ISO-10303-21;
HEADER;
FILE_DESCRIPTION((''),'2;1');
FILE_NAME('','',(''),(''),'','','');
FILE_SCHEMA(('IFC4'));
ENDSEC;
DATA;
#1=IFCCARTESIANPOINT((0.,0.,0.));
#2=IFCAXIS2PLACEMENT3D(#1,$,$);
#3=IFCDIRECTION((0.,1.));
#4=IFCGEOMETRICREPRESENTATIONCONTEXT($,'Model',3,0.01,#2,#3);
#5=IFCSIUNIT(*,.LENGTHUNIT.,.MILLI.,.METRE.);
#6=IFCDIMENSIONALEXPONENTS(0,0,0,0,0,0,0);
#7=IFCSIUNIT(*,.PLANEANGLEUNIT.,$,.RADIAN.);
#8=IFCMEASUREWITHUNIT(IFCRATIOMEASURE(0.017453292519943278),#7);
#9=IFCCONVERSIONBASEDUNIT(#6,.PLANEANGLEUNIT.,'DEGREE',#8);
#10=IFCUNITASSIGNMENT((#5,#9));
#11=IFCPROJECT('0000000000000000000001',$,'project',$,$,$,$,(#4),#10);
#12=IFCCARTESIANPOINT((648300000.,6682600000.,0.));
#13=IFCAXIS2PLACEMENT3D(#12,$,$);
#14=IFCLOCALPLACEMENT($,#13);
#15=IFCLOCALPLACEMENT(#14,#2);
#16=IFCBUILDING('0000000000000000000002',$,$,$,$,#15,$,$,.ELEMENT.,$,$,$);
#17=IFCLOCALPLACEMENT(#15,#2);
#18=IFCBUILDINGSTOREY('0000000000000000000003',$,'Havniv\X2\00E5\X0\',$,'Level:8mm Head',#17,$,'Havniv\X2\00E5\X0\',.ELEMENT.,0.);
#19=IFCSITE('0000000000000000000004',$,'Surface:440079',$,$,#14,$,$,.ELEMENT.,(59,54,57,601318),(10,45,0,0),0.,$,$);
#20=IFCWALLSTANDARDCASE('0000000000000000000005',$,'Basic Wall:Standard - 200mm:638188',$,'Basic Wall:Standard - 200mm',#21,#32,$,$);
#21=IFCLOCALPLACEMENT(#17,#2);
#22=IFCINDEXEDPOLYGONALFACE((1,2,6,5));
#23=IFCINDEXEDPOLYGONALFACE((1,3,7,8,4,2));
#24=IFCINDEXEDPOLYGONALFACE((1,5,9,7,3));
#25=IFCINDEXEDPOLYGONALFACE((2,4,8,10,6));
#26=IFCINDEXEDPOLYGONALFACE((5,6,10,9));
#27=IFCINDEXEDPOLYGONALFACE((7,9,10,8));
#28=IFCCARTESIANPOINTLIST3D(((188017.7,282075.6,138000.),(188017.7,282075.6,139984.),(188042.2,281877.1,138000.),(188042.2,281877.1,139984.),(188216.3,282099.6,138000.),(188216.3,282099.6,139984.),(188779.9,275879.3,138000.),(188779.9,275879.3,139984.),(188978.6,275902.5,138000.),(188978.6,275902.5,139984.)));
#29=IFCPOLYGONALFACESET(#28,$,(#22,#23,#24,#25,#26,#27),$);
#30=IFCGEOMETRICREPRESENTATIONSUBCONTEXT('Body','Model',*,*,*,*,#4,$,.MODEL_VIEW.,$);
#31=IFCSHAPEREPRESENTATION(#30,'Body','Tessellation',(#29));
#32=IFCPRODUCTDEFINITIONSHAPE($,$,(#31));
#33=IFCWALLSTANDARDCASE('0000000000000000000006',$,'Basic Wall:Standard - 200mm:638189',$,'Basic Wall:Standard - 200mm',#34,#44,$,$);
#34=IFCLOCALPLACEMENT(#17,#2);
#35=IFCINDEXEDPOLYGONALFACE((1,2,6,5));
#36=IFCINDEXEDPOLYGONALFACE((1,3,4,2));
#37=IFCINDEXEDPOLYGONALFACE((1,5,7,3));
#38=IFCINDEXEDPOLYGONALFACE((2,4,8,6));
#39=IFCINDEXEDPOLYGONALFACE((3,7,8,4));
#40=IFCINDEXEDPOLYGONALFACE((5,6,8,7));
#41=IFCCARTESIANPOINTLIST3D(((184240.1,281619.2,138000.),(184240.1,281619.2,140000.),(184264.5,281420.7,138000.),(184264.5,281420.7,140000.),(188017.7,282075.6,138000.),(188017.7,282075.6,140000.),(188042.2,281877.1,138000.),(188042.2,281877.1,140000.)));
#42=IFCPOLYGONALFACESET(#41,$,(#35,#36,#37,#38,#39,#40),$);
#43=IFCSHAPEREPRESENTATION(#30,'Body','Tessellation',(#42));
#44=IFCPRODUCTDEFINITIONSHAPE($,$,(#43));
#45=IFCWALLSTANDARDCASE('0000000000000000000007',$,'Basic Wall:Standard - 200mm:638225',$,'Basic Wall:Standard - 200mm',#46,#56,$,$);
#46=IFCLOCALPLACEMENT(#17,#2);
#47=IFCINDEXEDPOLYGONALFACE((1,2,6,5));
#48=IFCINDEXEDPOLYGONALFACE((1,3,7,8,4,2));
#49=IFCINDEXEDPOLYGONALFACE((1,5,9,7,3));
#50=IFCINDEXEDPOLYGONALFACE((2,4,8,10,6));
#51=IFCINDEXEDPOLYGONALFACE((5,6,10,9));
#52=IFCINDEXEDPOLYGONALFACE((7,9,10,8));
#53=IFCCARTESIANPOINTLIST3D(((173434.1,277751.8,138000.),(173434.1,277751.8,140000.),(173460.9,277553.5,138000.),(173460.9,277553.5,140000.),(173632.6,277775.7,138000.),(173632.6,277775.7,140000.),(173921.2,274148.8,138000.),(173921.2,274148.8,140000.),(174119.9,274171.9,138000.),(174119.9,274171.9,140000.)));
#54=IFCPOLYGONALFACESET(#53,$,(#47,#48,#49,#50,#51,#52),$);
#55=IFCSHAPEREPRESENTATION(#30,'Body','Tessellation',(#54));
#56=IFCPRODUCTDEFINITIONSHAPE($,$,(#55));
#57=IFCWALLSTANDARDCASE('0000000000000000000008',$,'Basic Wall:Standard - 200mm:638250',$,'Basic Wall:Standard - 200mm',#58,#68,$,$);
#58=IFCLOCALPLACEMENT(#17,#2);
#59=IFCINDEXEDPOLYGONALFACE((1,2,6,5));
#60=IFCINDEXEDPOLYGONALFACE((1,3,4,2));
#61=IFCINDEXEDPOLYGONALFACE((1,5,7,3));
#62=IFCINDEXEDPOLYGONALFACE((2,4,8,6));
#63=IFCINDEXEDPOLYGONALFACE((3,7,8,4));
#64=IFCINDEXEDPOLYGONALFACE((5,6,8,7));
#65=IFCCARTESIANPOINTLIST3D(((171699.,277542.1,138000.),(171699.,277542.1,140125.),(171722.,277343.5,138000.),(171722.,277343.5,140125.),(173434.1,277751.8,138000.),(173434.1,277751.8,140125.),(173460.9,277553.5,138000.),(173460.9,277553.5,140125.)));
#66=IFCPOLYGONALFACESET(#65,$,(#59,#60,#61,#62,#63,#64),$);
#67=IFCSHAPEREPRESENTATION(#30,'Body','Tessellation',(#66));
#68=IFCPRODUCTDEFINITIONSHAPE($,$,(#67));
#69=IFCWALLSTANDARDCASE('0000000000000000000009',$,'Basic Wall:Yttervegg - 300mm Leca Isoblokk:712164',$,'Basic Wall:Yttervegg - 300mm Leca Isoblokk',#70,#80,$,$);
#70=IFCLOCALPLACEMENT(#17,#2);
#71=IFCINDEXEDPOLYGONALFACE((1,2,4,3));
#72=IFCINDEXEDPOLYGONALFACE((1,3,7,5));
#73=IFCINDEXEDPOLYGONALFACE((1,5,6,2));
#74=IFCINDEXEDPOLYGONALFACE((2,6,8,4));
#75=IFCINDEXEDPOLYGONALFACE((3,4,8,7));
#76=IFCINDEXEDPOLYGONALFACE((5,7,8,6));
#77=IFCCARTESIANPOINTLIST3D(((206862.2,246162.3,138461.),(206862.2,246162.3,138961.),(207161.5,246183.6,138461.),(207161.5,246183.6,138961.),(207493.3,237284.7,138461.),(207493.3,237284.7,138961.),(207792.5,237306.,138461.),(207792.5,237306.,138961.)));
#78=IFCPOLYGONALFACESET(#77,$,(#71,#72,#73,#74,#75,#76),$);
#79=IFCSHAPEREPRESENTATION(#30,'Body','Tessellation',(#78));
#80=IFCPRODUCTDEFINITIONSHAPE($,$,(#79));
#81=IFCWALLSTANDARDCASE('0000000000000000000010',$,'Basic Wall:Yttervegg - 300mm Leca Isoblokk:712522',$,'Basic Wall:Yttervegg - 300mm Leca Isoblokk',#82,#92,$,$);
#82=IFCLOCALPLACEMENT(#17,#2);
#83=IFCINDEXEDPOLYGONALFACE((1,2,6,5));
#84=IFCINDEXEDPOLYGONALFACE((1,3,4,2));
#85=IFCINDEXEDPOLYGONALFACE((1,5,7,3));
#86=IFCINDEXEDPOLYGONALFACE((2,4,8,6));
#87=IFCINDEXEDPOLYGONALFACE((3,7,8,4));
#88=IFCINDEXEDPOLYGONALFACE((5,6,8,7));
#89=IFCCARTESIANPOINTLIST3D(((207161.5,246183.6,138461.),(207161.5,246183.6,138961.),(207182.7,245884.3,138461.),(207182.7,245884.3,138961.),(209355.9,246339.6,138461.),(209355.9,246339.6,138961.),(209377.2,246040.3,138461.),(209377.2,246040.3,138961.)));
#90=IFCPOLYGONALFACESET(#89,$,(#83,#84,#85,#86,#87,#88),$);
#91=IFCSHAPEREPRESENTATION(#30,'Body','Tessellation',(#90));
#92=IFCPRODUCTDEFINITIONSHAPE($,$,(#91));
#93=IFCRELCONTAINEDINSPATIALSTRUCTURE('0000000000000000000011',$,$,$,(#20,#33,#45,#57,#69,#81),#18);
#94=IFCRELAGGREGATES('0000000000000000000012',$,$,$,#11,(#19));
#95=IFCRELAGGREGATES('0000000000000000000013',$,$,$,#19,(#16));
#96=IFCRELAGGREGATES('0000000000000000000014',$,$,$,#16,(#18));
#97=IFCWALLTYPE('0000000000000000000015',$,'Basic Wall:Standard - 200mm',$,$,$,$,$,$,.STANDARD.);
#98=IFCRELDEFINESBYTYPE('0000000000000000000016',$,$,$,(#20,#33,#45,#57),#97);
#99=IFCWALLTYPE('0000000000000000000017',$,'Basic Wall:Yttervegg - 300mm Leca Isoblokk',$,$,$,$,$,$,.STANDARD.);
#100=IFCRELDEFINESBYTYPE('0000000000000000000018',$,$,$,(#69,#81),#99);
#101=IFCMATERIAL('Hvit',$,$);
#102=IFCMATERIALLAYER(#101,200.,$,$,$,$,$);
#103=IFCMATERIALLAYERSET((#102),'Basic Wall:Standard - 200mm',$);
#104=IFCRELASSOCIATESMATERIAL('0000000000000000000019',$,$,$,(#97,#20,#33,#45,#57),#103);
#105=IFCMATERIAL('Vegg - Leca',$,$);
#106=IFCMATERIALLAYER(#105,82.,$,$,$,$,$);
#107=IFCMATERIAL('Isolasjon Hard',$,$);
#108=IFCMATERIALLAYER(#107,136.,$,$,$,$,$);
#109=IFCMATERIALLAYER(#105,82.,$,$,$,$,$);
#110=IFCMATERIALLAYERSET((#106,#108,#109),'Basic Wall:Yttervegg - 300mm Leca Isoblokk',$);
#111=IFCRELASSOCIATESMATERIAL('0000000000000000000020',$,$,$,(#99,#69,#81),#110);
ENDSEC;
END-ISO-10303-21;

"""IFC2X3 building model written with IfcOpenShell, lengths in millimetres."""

from ifc_helpers import new_model, entity, si_unit, converted_unit, direction, frame, frame_2d, origin, place, context, subcontext, project, spatial, polyline, rectangle, outline, extrude, material, layer, layer_set, layer_usage, type_object, element, save


model = new_model("IFC2X3")

# Units and contexts
model_context = context("Model", 3, precision=0.01, world=origin(), true_north=direction((0.0, 1.0)))
body_context = subcontext(model_context, "Body", "Model", "MODEL_VIEW")
ifc_project = project(units=[si_unit("LENGTHUNIT", "METRE", prefix="MILLI"), converted_unit("PLANEANGLEUNIT", "DEGREE", entity("IfcRatioMeasure", 0.017453292519943278), si_unit("PLANEANGLEUNIT", "RADIAN"), dimensions=[0, 0, 0, 0, 0, 0, 0])], contexts=[model_context])

# Site, building, storey
site_placement = place(None, frame((648300000.0, 6682600000.0, 0.0)))
site = spatial("IfcSite", under=ifc_project, at=site_placement, Name="Surface:440079", CompositionType="ELEMENT", RefLatitude=(59, 54, 57, 601318), RefLongitude=(10, 45, 0, 0), RefElevation=0.0)
building_placement = place(site_placement, origin())
building = spatial("IfcBuilding", under=site, at=building_placement, CompositionType="ELEMENT")
storey_placement = place(building_placement, origin())
storey = spatial("IfcBuildingStorey", under=building, at=storey_placement, Name="Havnivå", ObjectType="Level:8mm Head", LongName="Havnivå", CompositionType="ELEMENT", Elevation=0.0)

# Walls
ifc_material_1 = material(Name="Hvit")
ifc_layer_1 = layer(ifc_material_1, 200.0)
ifc_layer_set_1 = layer_set([ifc_layer_1], Name="Basic Wall:Standard - 200mm")
wall_type_1 = type_object("IfcWallType", Name="Basic Wall:Standard - 200mm", PredefinedType="STANDARD", material=ifc_layer_set_1)
ifc_layer_usage_1 = layer_usage(ifc_layer_set_1, "AXIS2", "NEGATIVE", 100.0)
wall_1_placement = place(storey_placement, frame((188117.0, 282087.8, 138000.0), z_axis=(0.0, 0.0, 1.0), x_axis=(0.122083, -0.99252, 0.0)))
element("IfcWallStandardCase", 1, at=wall_1_placement, inside=storey, type_object=wall_type_1, material=ifc_layer_usage_1, Name="Basic Wall:Standard - 200mm:638188", ObjectType="Basic Wall:Standard - 200mm", context=body_context, shape_type="SweptSolid", body=[
    extrude(outline(polyline([(6242.9, -100.0), (6244.2, 100.0), (0.4, 100.0), (0.0, -100.0), (200.0, -100.0), (6242.9, -100.0)])), origin(), (0.0, 0.0, 1.0), 1984.0),
])
ifc_layer_usage_2 = layer_usage(ifc_layer_set_1, "AXIS2", "NEGATIVE", 100.0)
wall_2_placement = place(storey_placement, frame((184252.1, 281519.9, 138000.0), z_axis=(0.0, 0.0, 1.0), x_axis=(0.992781, 0.119939, 0.0)))
element("IfcWallStandardCase", 2, at=wall_2_placement, inside=storey, type_object=wall_type_1, material=ifc_layer_usage_2, Name="Basic Wall:Standard - 200mm:638189", ObjectType="Basic Wall:Standard - 200mm", context=body_context, shape_type="SweptSolid", body=[
    extrude(outline(polyline([(3805.5, -100.0), (3805.1, 100.0), (0.0, 100.0), (0.4, -100.0), (3805.5, -100.0)])), origin(), (0.0, 0.0, 1.0), 2000.0),
])
ifc_layer_usage_3 = layer_usage(ifc_layer_set_1, "AXIS2", "NEGATIVE", 100.0)
wall_3_placement = place(storey_placement, frame((173533.2, 277765.2, 138000.0), z_axis=(0.0, 0.0, 1.0), x_axis=(0.133992, -0.990982, 0.0)))
element("IfcWallStandardCase", 3, at=wall_3_placement, inside=storey, type_object=wall_type_1, material=ifc_layer_usage_3, Name="Basic Wall:Standard - 200mm:638225", ObjectType="Basic Wall:Standard - 200mm", context=body_context, shape_type="SweptSolid", body=[
    extrude(outline(polyline([(3635.7, -100.0), (3639.4, 100.0), (2.8, 100.0), (0.0, -100.0), (200.0, -100.0), (3635.7, -100.0)])), origin(), (0.0, 0.0, 1.0), 2000.0),
])
ifc_layer_usage_4 = layer_usage(ifc_layer_set_1, "AXIS2", "NEGATIVE", 100.0)
wall_4_placement = place(storey_placement, frame((171710.0, 277442.7, 138000.0), z_axis=(0.0, 0.0, 1.0), x_axis=(0.992781, 0.119939, 0.0)))
element("IfcWallStandardCase", 4, at=wall_4_placement, inside=storey, type_object=wall_type_1, material=ifc_layer_usage_4, Name="Basic Wall:Standard - 200mm:638250", ObjectType="Basic Wall:Standard - 200mm", context=body_context, shape_type="SweptSolid", body=[
    extrude(outline(polyline([(1751.5, -100.0), (1748.7, 100.0), (1.0, 100.0), (0.0, -100.0), (1751.5, -100.0)])), origin(), (0.0, 0.0, 1.0), 2125.0),
])
ifc_material_2 = material(Name="Vegg - Leca")
ifc_layer_2 = layer(ifc_material_2, 82.0)
ifc_material_3 = material(Name="Isolasjon Hard")
ifc_layer_3 = layer(ifc_material_3, 136.0)
ifc_layer_4 = layer(ifc_material_2, 82.0)
ifc_layer_set_2 = layer_set([ifc_layer_2, ifc_layer_3, ifc_layer_4], Name="Basic Wall:Yttervegg - 300mm Leca Isoblokk")
ifc_layer_usage_5 = layer_usage(ifc_layer_set_2, "AXIS2", "POSITIVE", -150.0)
wall_type_2 = type_object("IfcWallType", Name="Basic Wall:Yttervegg - 300mm Leca Isoblokk", PredefinedType="STANDARD", material=ifc_layer_set_2)
wall_5_placement = place(storey_placement, frame((207011.8, 246172.9, 138461.0), z_axis=(0.0, 0.0, 1.0), x_axis=(0.070908, -0.997483, 0.0)))
element("IfcWallStandardCase", 5, at=wall_5_placement, inside=storey, type_object=wall_type_2, material=ifc_layer_usage_5, Name="Basic Wall:Yttervegg - 300mm Leca Isoblokk:712164", ObjectType="Basic Wall:Yttervegg - 300mm Leca Isoblokk", context=body_context, shape_type="SweptSolid", body=[
    extrude(rectangle(XDim=8900.0, YDim=300.0, at=frame_2d((4450.0, 0.0), x_axis=(-1.0, 0.0))), origin(), (0.0, 0.0, 1.0), 500.0),
])
ifc_layer_usage_6 = layer_usage(ifc_layer_set_2, "AXIS2", "NEGATIVE", 150.0)
wall_6_placement = place(storey_placement, frame((207172.1, 246034.0, 138461.0), z_axis=(0.0, 0.0, 1.0), x_axis=(0.997483, 0.070908, 0.0)))
element("IfcWallStandardCase", 6, at=wall_6_placement, inside=storey, type_object=wall_type_2, material=ifc_layer_usage_6, Name="Basic Wall:Yttervegg - 300mm Leca Isoblokk:712522", ObjectType="Basic Wall:Yttervegg - 300mm Leca Isoblokk", context=body_context, shape_type="SweptSolid", body=[
    extrude(rectangle(XDim=2200.0, YDim=300.0, at=frame_2d((1100.0, 0.0), x_axis=(-1.0, 0.0))), origin(), (0.0, 0.0, 1.0), 500.0),
])

save(model, "model.ifc")
